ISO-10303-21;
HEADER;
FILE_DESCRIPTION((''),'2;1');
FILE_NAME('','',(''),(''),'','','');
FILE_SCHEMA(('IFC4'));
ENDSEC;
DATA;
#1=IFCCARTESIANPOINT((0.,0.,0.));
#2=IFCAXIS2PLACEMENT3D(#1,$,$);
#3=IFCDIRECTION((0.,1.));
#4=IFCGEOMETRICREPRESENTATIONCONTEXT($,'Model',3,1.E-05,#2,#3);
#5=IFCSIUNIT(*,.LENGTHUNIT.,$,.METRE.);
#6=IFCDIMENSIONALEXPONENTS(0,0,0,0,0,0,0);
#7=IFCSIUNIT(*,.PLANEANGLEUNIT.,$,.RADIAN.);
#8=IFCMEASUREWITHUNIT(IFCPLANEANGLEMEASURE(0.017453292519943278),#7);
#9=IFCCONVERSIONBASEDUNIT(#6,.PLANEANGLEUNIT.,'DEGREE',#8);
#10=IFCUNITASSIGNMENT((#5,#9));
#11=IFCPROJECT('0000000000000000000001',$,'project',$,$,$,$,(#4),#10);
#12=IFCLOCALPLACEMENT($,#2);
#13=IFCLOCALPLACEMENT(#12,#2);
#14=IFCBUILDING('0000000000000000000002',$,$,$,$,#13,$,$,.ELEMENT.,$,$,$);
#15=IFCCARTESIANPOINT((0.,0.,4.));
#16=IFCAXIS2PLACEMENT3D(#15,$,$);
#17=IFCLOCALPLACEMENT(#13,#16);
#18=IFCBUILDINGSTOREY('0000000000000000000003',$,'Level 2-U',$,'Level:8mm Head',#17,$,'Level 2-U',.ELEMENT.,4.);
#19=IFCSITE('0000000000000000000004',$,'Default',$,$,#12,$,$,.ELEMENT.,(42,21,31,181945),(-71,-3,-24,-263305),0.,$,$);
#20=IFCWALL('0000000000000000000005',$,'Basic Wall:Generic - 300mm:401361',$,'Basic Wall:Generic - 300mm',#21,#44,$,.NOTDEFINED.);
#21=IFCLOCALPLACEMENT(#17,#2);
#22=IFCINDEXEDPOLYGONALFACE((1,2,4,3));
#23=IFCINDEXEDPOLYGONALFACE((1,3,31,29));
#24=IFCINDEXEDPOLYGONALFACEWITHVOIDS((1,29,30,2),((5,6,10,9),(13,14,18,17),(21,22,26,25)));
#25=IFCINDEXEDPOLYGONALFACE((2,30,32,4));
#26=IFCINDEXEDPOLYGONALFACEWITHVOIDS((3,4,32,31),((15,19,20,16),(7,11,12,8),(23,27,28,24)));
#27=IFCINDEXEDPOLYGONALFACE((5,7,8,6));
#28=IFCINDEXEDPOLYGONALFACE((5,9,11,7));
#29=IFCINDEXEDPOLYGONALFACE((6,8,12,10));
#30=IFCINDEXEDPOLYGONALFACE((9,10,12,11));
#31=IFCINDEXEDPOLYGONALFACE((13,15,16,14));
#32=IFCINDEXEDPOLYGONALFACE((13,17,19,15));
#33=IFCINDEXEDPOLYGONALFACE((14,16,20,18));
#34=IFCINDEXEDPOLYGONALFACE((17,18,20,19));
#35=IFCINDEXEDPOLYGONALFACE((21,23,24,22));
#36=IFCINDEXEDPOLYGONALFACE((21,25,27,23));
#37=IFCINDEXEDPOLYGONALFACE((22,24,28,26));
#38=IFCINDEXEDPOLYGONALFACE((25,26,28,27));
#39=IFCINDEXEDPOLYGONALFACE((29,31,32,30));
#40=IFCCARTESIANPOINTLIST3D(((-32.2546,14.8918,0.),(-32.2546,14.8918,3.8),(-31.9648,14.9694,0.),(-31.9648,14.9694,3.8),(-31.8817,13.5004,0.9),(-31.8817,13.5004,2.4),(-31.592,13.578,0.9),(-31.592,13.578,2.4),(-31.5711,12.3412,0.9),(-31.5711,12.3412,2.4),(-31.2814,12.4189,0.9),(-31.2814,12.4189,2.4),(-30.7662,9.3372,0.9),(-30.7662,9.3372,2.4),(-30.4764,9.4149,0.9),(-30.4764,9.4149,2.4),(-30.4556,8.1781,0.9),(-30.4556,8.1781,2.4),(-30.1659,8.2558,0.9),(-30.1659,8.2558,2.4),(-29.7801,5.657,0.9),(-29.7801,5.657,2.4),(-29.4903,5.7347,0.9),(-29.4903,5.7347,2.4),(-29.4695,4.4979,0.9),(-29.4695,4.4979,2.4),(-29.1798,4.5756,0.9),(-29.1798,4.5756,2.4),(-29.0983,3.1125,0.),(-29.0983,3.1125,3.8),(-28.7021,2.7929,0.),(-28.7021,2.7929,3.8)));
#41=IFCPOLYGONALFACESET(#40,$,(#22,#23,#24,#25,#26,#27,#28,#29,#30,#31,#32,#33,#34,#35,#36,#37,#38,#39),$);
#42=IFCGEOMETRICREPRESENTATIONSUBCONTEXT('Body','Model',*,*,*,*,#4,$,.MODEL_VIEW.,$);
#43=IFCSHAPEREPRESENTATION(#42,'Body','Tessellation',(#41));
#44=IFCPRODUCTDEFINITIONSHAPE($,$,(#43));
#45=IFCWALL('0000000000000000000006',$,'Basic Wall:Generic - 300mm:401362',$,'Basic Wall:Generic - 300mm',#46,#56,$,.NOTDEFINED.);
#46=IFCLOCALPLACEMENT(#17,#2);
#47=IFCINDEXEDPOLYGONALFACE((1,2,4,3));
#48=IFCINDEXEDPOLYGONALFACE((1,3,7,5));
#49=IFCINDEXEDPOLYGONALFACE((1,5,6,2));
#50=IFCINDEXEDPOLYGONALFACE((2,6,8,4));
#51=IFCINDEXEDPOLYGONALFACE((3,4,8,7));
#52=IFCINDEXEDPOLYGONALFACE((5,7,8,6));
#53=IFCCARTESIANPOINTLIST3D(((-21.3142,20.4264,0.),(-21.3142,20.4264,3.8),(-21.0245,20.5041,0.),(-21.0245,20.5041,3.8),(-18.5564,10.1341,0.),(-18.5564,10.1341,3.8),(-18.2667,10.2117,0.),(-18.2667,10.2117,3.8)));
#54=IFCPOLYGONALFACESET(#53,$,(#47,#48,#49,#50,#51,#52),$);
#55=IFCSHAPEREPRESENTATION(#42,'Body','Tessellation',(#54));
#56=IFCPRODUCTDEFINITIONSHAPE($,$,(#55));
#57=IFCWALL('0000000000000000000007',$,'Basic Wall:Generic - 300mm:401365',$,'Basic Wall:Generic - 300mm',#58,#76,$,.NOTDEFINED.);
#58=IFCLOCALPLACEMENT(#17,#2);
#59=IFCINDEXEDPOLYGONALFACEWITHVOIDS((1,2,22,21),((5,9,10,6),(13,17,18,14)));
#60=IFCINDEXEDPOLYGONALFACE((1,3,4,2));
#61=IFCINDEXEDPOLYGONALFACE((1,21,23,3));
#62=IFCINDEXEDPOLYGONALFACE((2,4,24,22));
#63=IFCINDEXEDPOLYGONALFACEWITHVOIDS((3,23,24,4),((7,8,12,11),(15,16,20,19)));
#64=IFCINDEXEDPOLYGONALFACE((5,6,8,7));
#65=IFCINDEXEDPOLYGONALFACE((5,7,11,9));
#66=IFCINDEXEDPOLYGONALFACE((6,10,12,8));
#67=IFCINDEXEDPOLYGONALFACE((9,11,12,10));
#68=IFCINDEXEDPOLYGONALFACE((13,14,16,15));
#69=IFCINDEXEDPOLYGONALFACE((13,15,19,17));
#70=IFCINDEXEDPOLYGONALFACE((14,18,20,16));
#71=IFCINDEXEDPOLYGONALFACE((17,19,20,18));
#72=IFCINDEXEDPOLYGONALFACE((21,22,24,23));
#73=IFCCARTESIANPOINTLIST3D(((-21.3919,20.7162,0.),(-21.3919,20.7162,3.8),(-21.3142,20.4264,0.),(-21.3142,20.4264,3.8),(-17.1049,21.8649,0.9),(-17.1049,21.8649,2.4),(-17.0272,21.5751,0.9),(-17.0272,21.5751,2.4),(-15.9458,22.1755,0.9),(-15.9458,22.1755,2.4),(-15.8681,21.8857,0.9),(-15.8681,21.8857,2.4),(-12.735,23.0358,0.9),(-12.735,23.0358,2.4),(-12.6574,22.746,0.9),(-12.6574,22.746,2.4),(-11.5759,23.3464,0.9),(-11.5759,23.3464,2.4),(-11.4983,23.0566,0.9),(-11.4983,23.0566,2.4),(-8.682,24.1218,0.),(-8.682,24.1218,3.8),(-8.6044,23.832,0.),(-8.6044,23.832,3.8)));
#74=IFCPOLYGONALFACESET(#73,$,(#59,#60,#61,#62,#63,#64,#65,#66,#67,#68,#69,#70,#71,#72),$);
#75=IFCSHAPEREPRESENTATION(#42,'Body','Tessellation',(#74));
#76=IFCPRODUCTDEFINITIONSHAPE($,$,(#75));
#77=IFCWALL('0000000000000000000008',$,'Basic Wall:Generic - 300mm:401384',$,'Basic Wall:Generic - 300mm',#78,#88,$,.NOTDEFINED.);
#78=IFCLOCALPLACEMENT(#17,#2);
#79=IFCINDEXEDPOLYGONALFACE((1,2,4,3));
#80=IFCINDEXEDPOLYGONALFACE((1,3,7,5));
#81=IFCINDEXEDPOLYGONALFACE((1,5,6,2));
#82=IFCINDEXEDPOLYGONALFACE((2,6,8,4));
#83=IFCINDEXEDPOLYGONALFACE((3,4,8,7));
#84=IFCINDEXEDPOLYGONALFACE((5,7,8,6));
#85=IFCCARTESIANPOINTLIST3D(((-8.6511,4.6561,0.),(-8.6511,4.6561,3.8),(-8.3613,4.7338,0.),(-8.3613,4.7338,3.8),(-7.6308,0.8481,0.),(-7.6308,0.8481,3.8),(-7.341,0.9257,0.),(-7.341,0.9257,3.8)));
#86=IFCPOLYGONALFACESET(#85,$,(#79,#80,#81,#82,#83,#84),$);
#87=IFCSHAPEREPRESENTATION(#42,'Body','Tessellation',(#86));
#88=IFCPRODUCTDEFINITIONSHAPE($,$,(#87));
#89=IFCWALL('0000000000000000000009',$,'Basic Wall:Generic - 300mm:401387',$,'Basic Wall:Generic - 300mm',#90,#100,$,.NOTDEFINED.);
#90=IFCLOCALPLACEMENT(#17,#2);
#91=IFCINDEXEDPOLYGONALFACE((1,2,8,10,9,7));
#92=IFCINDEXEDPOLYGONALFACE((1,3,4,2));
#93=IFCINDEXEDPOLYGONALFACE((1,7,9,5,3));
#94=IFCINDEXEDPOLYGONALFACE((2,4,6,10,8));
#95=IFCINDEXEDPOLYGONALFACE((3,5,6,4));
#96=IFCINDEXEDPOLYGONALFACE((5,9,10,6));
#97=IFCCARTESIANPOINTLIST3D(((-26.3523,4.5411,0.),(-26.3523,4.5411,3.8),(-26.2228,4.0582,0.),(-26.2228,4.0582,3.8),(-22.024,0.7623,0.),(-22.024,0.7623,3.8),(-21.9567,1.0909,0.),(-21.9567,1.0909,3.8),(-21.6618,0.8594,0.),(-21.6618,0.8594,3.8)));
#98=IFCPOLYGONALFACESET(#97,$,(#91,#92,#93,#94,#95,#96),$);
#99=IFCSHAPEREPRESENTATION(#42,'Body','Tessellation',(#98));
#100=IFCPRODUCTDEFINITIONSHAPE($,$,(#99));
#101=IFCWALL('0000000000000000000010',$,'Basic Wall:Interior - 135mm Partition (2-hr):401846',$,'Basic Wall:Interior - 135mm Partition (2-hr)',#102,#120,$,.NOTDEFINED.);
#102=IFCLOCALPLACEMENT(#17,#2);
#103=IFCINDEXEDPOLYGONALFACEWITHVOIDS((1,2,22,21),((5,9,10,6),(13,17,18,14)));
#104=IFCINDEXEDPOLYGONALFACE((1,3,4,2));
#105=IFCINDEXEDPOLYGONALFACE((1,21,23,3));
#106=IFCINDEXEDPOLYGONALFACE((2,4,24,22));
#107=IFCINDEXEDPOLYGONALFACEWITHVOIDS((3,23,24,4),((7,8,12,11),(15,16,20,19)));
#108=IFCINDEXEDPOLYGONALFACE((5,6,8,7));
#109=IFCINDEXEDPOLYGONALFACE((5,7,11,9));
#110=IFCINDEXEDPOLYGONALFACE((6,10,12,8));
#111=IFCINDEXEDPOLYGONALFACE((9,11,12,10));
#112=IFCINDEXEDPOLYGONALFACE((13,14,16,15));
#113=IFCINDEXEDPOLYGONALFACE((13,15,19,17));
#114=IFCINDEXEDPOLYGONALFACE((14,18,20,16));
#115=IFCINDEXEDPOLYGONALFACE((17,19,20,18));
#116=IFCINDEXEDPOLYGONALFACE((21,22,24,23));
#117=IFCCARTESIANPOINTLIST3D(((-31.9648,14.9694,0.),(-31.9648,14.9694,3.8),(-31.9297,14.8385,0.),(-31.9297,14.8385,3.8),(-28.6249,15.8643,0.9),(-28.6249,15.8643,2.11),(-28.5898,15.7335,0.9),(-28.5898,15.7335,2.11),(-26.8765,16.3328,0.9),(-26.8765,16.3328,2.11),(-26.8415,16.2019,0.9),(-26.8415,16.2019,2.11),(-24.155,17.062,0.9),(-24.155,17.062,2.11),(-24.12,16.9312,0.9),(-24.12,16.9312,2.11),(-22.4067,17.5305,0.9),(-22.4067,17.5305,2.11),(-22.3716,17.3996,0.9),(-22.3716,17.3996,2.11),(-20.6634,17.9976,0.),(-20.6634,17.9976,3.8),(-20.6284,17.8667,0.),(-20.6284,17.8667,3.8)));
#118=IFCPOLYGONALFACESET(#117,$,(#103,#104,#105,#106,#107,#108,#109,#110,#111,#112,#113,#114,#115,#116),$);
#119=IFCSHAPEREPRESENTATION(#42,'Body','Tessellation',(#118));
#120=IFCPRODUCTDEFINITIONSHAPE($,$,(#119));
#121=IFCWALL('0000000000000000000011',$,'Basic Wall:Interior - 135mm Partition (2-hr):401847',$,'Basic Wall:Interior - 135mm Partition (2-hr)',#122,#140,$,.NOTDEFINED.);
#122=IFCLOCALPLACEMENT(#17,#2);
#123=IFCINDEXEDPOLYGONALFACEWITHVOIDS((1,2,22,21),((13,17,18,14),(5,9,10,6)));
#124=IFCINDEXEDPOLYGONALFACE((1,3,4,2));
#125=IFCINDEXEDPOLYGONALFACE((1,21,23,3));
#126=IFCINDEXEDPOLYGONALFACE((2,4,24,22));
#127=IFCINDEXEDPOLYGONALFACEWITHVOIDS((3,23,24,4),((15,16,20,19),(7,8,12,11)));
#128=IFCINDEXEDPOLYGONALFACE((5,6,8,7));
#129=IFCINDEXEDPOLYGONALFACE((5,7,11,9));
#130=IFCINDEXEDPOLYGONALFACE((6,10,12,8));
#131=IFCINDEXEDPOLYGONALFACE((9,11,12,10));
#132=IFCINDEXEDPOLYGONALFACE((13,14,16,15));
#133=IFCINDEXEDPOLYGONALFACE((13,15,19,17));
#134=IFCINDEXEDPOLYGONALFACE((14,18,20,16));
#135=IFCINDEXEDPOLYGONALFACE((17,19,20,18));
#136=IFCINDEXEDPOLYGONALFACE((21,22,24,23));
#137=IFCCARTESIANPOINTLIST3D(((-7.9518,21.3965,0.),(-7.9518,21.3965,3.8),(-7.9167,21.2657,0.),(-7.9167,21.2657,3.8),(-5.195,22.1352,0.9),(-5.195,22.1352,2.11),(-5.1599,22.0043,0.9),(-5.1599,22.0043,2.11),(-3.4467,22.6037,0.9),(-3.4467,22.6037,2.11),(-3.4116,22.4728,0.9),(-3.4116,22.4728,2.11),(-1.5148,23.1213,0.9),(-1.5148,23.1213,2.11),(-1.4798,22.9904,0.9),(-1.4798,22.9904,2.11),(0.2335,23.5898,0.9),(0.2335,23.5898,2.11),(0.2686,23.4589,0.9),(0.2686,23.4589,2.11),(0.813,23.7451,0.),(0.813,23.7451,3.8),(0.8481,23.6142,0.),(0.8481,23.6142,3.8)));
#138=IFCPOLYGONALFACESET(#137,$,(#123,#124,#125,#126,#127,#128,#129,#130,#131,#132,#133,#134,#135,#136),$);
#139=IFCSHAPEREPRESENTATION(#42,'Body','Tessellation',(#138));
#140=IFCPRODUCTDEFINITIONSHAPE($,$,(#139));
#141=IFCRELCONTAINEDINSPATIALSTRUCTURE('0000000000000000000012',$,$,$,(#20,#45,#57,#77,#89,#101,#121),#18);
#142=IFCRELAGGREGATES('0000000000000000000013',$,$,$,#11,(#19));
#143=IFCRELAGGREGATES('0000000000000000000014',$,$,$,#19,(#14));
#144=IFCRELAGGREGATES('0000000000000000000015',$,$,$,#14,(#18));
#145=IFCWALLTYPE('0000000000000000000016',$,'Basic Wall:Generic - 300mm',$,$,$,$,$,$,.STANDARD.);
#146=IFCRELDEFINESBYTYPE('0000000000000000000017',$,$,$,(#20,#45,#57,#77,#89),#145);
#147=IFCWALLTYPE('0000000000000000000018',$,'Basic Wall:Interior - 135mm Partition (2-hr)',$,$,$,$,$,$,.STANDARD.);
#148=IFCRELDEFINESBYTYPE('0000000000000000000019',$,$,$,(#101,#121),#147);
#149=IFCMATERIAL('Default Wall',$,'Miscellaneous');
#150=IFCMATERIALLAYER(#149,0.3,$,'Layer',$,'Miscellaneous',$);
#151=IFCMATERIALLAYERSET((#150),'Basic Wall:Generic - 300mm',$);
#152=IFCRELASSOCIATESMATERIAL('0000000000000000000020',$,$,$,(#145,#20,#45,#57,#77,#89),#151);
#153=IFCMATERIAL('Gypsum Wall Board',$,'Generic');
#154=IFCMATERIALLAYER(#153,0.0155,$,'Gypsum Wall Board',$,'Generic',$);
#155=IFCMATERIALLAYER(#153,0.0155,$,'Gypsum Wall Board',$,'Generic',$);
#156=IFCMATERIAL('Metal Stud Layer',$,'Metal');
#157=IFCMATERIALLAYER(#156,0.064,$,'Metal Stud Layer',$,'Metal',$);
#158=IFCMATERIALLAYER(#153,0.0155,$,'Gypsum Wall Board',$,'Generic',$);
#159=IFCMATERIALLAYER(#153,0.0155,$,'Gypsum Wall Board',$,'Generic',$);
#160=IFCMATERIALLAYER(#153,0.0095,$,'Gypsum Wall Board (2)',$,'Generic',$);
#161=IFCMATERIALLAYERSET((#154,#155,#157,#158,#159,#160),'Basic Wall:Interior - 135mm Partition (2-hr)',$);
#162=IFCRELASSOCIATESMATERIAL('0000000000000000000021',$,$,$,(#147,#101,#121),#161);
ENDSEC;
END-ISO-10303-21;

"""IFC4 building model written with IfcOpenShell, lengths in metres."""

from ifc_helpers import new_model, entity, si_unit, converted_unit, direction, frame, frame_2d, origin, place, context, subcontext, project, spatial, polyline, rectangle, outline, extrude, material, layer, layer_set, layer_usage, type_object, element, save


model = new_model("IFC4")

# Units and contexts
model_context = context("Model", 3, precision=1e-05, world=origin(), true_north=direction((0.0, 1.0)))
body_context = subcontext(model_context, "Body", "Model", "MODEL_VIEW")
ifc_project = project(units=[si_unit("LENGTHUNIT", "METRE"), converted_unit("PLANEANGLEUNIT", "DEGREE", entity("IfcPlaneAngleMeasure", 0.017453292519943278), si_unit("PLANEANGLEUNIT", "RADIAN"), dimensions=[0, 0, 0, 0, 0, 0, 0])], contexts=[model_context])

# Site, building, storey
site_placement = place(None, origin())
site = spatial("IfcSite", under=ifc_project, at=site_placement, Name="Default", CompositionType="ELEMENT", RefLatitude=(42, 21, 31, 181945), RefLongitude=(-71, -3, -24, -263305), RefElevation=0.0)
building_placement = place(site_placement, origin())
building = spatial("IfcBuilding", under=site, at=building_placement, CompositionType="ELEMENT")
storey_placement = place(building_placement, frame((0.0, 0.0, 4.0)))
storey = spatial("IfcBuildingStorey", under=building, at=storey_placement, Name="Level 2-U", ObjectType="Level:8mm Head", LongName="Level 2-U", CompositionType="ELEMENT", Elevation=4.0)

# Wall, openings
ifc_material_1 = material(Name="Default Wall", Category="Miscellaneous")
ifc_layer_1 = layer(ifc_material_1, 0.3, Name="Layer", Category="Miscellaneous")
ifc_layer_set_1 = layer_set([ifc_layer_1], Name="Basic Wall:Generic - 300mm")
ifc_layer_usage_1 = layer_usage(ifc_layer_set_1, "AXIS2", "NEGATIVE", 0.15)
wall_type_1 = type_object("IfcWallType", Name="Basic Wall:Generic - 300mm", PredefinedType="STANDARD", material=ifc_layer_set_1)
wall_1_placement = place(storey_placement, frame((-32.1097, 14.9306, 0.0), z_axis=(0.0, 0.0, 1.0), x_axis=(0.258819, -0.965926, 0.0)))
wall_1 = element("IfcWall", 1, at=wall_1_placement, inside=storey, type_object=wall_type_1, material=ifc_layer_usage_1, Name="Basic Wall:Generic - 300mm:401361", ObjectType="Basic Wall:Generic - 300mm", PredefinedType="NOTDEFINED", context=body_context, shape_type="SweptSolid", body=[
    extrude(outline(polyline([(12.1948, -0.15), (12.606, 0.15), (12.097, 0.15), (0.0, 0.15), (0.0, -0.15), (12.1948, -0.15)])), origin(), (0.0, 0.0, 1.0), 3.8),
])
opening_1_placement = place(wall_1_placement, frame((10.7605, 0.15, 0.9)))
element("IfcOpeningElement", 2, at=opening_1_placement, cuts=wall_1, PredefinedType="OPENING", context=body_context, shape_type="SweptSolid", body=[
    extrude(rectangle(XDim=1.5, YDim=1.2, at=frame_2d((0.75, 0.6), x_axis=(-1.0, 0.0))), frame((0.0, 0.0, 0.0), z_axis=(0.0, -1.0, 0.0), x_axis=(0.0, 0.0, 1.0)), (0.0, 0.0, 1.0), 0.3),
])
opening_2_placement = place(wall_1_placement, frame((6.9505, 0.15, 0.9)))
element("IfcOpeningElement", 3, at=opening_2_placement, cuts=wall_1, PredefinedType="OPENING", context=body_context, shape_type="SweptSolid", body=[
    extrude(rectangle(XDim=1.5, YDim=1.2, at=frame_2d((0.75, 0.6), x_axis=(-1.0, 0.0))), frame((0.0, 0.0, 0.0), z_axis=(0.0, -1.0, 0.0), x_axis=(0.0, 0.0, 1.0)), (0.0, 0.0, 1.0), 0.3),
])
opening_3_placement = place(wall_1_placement, frame((2.6405, 0.15, 0.9)))
element("IfcOpeningElement", 4, at=opening_3_placement, cuts=wall_1, PredefinedType="OPENING", context=body_context, shape_type="SweptSolid", body=[
    extrude(rectangle(XDim=1.5, YDim=1.2, at=frame_2d((0.75, 0.6), x_axis=(-1.0, 0.0))), frame((0.0, 0.0, 0.0), z_axis=(0.0, -1.0, 0.0), x_axis=(0.0, 0.0, 1.0)), (0.0, 0.0, 1.0), 0.3),
])

# Wall
wall_2_placement = place(storey_placement, frame((-18.4115, 10.1729, 0.0), z_axis=(0.0, 0.0, 1.0), x_axis=(-0.258819, 0.965926, 0.0)))
element("IfcWall", 5, at=wall_2_placement, inside=storey, type_object=wall_type_1, material=ifc_layer_usage_1, Name="Basic Wall:Generic - 300mm:401362", ObjectType="Basic Wall:Generic - 300mm", PredefinedType="NOTDEFINED", context=body_context, shape_type="SweptSolid", body=[
    extrude(rectangle(XDim=10.6554, YDim=0.3, at=frame_2d((5.3277, 0.0), x_axis=(-1.0, 0.0))), origin(), (0.0, 0.0, 1.0), 3.8),
])

# Wall, openings
wall_3_placement = place(storey_placement, frame((-21.3531, 20.5713, 0.0), z_axis=(0.0, 0.0, 1.0), x_axis=(0.965926, 0.258819, 0.0)))
wall_3 = element("IfcWall", 6, at=wall_3_placement, inside=storey, type_object=wall_type_1, material=ifc_layer_usage_1, Name="Basic Wall:Generic - 300mm:401365", ObjectType="Basic Wall:Generic - 300mm", PredefinedType="NOTDEFINED", context=body_context, shape_type="SweptSolid", body=[
    extrude(rectangle(XDim=13.1583, YDim=0.3, at=frame_2d((6.5791, 0.0), x_axis=(-1.0, 0.0))), origin(), (0.0, 0.0, 1.0), 3.8),
])
opening_4_placement = place(wall_3_placement, frame((4.4383, -0.15, 0.9)))
element("IfcOpeningElement", 7, at=opening_4_placement, cuts=wall_3, PredefinedType="OPENING", context=body_context, shape_type="SweptSolid", body=[
    extrude(rectangle(XDim=1.5, YDim=1.2, at=frame_2d((0.75, 0.6), x_axis=(-1.0, 0.0))), frame((0.0, 0.0, 0.0), z_axis=(0.0, 1.0, 0.0), x_axis=(0.0, 0.0, 1.0)), (0.0, 0.0, 1.0), 0.3),
])
opening_5_placement = place(wall_3_placement, frame((8.9622, -0.15, 0.9)))
element("IfcOpeningElement", 8, at=opening_5_placement, cuts=wall_3, PredefinedType="OPENING", context=body_context, shape_type="SweptSolid", body=[
    extrude(rectangle(XDim=1.5, YDim=1.2, at=frame_2d((0.75, 0.6), x_axis=(-1.0, 0.0))), frame((0.0, 0.0, 0.0), z_axis=(0.0, 1.0, 0.0), x_axis=(0.0, 0.0, 1.0)), (0.0, 0.0, 1.0), 0.3),
])

# Walls
wall_4_placement = place(storey_placement, frame((-8.5062, 4.6949, 0.0), z_axis=(0.0, 0.0, 1.0), x_axis=(0.258819, -0.965926, 0.0)))
element("IfcWall", 9, at=wall_4_placement, inside=storey, type_object=wall_type_1, material=ifc_layer_usage_1, Name="Basic Wall:Generic - 300mm:401384", ObjectType="Basic Wall:Generic - 300mm", PredefinedType="NOTDEFINED", context=body_context, shape_type="SweptSolid", body=[
    extrude(rectangle(XDim=3.9424, YDim=0.3, at=frame_2d((1.9712, 0.0), x_axis=(-1.0, 0.0))), origin(), (0.0, 0.0, 1.0), 3.8),
])
wall_5_placement = place(storey_placement, frame((-26.4449, 4.4232, 0.0), z_axis=(0.0, 0.0, 1.0), x_axis=(0.786611, -0.617449, 0.0)))
element("IfcWall", 10, at=wall_5_placement, inside=storey, type_object=wall_type_1, material=ifc_layer_usage_1, Name="Basic Wall:Generic - 300mm:401387", ObjectType="Basic Wall:Generic - 300mm", PredefinedType="NOTDEFINED", context=body_context, shape_type="SweptSolid", body=[
    extrude(outline(polyline([(5.7379, -0.15), (5.9629, 0.15), (5.5879, 0.15), (0.0, 0.15), (0.4, -0.15), (5.7379, -0.15)])), origin(), (0.0, 0.0, 1.0), 3.8),
])

# Walls, openings
ifc_material_2 = material(Name="Gypsum Wall Board", Category="Generic")
ifc_layer_2 = layer(ifc_material_2, 0.0155, Name="Gypsum Wall Board", Category="Generic")
ifc_layer_3 = layer(ifc_material_2, 0.0155, Name="Gypsum Wall Board", Category="Generic")
ifc_material_3 = material(Name="Metal Stud Layer", Category="Metal")
ifc_layer_4 = layer(ifc_material_3, 0.064, Name="Metal Stud Layer", Category="Metal")
ifc_layer_5 = layer(ifc_material_2, 0.0155, Name="Gypsum Wall Board", Category="Generic")
ifc_layer_6 = layer(ifc_material_2, 0.0155, Name="Gypsum Wall Board", Category="Generic")
ifc_layer_7 = layer(ifc_material_2, 0.0095, Name="Gypsum Wall Board (2)", Category="Generic")
ifc_layer_set_2 = layer_set([ifc_layer_2, ifc_layer_3, ifc_layer_4, ifc_layer_5, ifc_layer_6, ifc_layer_7], Name="Basic Wall:Interior - 135mm Partition (2-hr)")
ifc_layer_usage_2 = layer_usage(ifc_layer_set_2, "AXIS2", "NEGATIVE", 0.0677)
wall_type_2 = type_object("IfcWallType", Name="Basic Wall:Interior - 135mm Partition (2-hr)", PredefinedType="STANDARD", material=ifc_layer_set_2)
wall_6_placement = place(storey_placement, frame((-20.6459, 17.9322, 0.0), z_axis=(0.0, 0.0, 1.0), x_axis=(-0.965926, -0.258819, 0.0)))
wall_6 = element("IfcWall", 11, at=wall_6_placement, inside=storey, type_object=wall_type_2, material=ifc_layer_usage_2, Name="Basic Wall:Interior - 135mm Partition (2-hr):401846", ObjectType="Basic Wall:Interior - 135mm Partition (2-hr)", PredefinedType="NOTDEFINED", context=body_context, shape_type="SweptSolid", body=[
    extrude(rectangle(XDim=11.7, YDim=0.1355, at=frame_2d((5.85, 0.0), x_axis=(-1.0, 0.0))), origin(), (0.0, 0.0, 1.0), 3.8),
])
opening_6_placement = place(wall_6_placement, frame((3.6147, 0.0677, 0.9)))
element("IfcOpeningElement", 12, at=opening_6_placement, cuts=wall_6, PredefinedType="OPENING", context=body_context, shape_type="SweptSolid", body=[
    extrude(rectangle(XDim=1.21, YDim=1.81, at=frame_2d((0.605, 0.905), x_axis=(-1.0, 0.0))), frame((0.0, 0.0, 0.0), z_axis=(0.0, -1.0, 0.0), x_axis=(0.0, 0.0, 1.0)), (0.0, 0.0, 1.0), 0.1355),
])
opening_7_placement = place(wall_6_placement, frame((8.2423, 0.0677, 0.9)))
element("IfcOpeningElement", 13, at=opening_7_placement, cuts=wall_6, PredefinedType="OPENING", context=body_context, shape_type="SweptSolid", body=[
    extrude(rectangle(XDim=1.21, YDim=1.81, at=frame_2d((0.605, 0.905), x_axis=(-1.0, 0.0))), frame((0.0, 0.0, 0.0), z_axis=(0.0, -1.0, 0.0), x_axis=(0.0, 0.0, 1.0)), (0.0, 0.0, 1.0), 0.1355),
])
wall_7_placement = place(storey_placement, frame((-7.9342, 21.3311, 0.0), z_axis=(0.0, 0.0, 1.0), x_axis=(0.965926, 0.258819, 0.0)))
wall_7 = element("IfcWall", 14, at=wall_7_placement, inside=storey, type_object=wall_type_2, material=ifc_layer_usage_2, Name="Basic Wall:Interior - 135mm Partition (2-hr):401847", ObjectType="Basic Wall:Interior - 135mm Partition (2-hr)", PredefinedType="NOTDEFINED", context=body_context, shape_type="SweptSolid", body=[
    extrude(rectangle(XDim=9.074, YDim=0.1355, at=frame_2d((4.537, 0.0), x_axis=(-1.0, 0.0))), origin(), (0.0, 0.0, 1.0), 3.8),
])
opening_8_placement = place(wall_7_placement, frame((2.854, -0.0678, 0.9)))
element("IfcOpeningElement", 15, at=opening_8_placement, cuts=wall_7, PredefinedType="OPENING", context=body_context, shape_type="SweptSolid", body=[
    extrude(rectangle(XDim=1.21, YDim=1.81, at=frame_2d((0.605, 0.905), x_axis=(-1.0, 0.0))), frame((0.0, 0.0, 0.0), z_axis=(0.0, 1.0, 0.0), x_axis=(0.0, 0.0, 1.0)), (0.0, 0.0, 1.0), 0.1355),
])
opening_9_placement = place(wall_7_placement, frame((8.474, 0.0677, 0.9)))
element("IfcOpeningElement", 16, at=opening_9_placement, cuts=wall_7, PredefinedType="OPENING", context=body_context, shape_type="SweptSolid", body=[
    extrude(rectangle(XDim=1.21, YDim=1.81, at=frame_2d((0.605, 0.905), x_axis=(-1.0, 0.0))), frame((0.0, 0.0, 0.0), z_axis=(0.0, -1.0, 0.0), x_axis=(0.0, 0.0, 1.0)), (0.0, 0.0, 1.0), 0.1355),
])

save(model, "model.ifc")
